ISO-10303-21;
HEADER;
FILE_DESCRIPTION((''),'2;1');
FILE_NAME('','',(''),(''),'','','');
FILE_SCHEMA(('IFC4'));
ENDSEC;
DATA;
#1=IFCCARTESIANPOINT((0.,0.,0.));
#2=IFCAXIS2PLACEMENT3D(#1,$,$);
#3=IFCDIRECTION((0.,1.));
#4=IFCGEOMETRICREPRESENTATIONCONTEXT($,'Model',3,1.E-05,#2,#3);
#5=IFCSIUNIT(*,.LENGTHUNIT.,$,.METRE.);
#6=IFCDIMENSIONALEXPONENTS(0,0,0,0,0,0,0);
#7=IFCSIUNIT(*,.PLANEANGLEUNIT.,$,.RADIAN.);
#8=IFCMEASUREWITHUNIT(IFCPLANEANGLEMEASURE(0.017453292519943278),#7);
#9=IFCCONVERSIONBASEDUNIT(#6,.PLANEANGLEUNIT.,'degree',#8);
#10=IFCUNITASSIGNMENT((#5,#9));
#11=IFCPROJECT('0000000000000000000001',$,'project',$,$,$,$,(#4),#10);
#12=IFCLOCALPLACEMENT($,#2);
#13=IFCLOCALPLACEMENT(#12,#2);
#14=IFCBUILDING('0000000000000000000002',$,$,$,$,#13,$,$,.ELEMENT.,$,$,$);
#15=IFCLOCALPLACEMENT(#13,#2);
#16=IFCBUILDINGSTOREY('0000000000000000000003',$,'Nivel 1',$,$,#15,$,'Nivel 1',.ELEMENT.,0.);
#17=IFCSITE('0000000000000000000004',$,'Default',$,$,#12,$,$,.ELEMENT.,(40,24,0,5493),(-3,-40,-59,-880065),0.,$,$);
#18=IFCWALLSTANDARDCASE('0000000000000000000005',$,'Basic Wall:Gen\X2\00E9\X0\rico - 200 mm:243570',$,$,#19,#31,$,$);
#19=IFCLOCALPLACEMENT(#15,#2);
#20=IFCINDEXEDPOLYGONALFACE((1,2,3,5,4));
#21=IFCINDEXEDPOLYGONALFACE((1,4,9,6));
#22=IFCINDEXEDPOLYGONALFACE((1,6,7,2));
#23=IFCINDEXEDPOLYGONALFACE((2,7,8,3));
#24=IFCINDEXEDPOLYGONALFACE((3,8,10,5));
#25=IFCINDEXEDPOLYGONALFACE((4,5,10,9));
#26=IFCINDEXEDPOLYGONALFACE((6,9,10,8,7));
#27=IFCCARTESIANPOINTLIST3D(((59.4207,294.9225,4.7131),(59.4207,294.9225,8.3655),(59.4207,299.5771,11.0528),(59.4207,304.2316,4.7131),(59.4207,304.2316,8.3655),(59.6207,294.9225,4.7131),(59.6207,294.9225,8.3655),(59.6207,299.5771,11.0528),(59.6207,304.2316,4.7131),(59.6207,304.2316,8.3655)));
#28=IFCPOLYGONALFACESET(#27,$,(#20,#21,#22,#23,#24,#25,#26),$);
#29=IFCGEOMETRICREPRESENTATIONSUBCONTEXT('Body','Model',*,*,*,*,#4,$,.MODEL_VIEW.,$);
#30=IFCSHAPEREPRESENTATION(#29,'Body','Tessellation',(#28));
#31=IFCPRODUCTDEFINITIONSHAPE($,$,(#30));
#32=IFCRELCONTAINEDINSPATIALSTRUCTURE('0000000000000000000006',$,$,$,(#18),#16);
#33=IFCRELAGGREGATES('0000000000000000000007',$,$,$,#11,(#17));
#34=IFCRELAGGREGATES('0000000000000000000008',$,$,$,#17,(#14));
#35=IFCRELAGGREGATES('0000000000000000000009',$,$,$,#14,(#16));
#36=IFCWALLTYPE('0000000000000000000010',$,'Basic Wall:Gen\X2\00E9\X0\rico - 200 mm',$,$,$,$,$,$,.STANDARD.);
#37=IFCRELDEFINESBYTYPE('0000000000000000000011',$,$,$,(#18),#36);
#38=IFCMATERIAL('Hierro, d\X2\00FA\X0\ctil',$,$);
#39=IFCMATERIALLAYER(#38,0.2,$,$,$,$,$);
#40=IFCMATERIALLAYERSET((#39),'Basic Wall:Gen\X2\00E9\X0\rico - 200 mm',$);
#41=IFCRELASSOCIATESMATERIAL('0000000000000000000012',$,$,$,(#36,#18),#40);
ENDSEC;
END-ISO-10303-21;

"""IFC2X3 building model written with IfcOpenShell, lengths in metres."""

from ifc_helpers import new_model, entity, si_unit, converted_unit, direction, frame, frame_2d, origin, place, context, subcontext, project, spatial, polyline, rectangle, extrude, clip, bounded_halfspace, material, layer, layer_set, layer_usage, type_object, element, save


model = new_model("IFC2X3")

# Units and contexts
model_context = context("Model", 3, precision=1e-05, world=origin(), true_north=direction((0.0, 1.0)))
body_context = subcontext(model_context, "Body", "Model", "MODEL_VIEW")
ifc_project = project(units=[si_unit("LENGTHUNIT", "METRE"), converted_unit("PLANEANGLEUNIT", "degree", entity("IfcPlaneAngleMeasure", 0.017453292519943278), si_unit("PLANEANGLEUNIT", "RADIAN"), dimensions=[0, 0, 0, 0, 0, 0, 0])], contexts=[model_context])

# Site, building, storey
site_placement = place(None, origin())
site = spatial("IfcSite", under=ifc_project, at=site_placement, Name="Default", CompositionType="ELEMENT", RefLatitude=(40, 24, 0, 5493), RefLongitude=(-3, -40, -59, -880065), RefElevation=0.0)
building_placement = place(site_placement, origin())
building = spatial("IfcBuilding", under=site, at=building_placement, CompositionType="ELEMENT")
storey_placement = place(building_placement, origin())
storey = spatial("IfcBuildingStorey", under=building, at=storey_placement, Name="Nivel 1", LongName="Nivel 1", CompositionType="ELEMENT", Elevation=0.0)

# Wall
ifc_material_1 = material(Name="Hierro, dúctil")
ifc_layer_1 = layer(ifc_material_1, 0.2)
ifc_layer_set_1 = layer_set([ifc_layer_1], Name="Basic Wall:Genérico - 200 mm")
wall_type = type_object("IfcWallType", Name="Basic Wall:Genérico - 200 mm", PredefinedType="STANDARD", material=ifc_layer_set_1)
ifc_layer_usage_1 = layer_usage(ifc_layer_set_1, "AXIS2", "NEGATIVE", 0.1)
wall_1_placement = place(storey_placement, frame((59.5207, 304.2316, 4.7131), z_axis=(0.0, 0.0, 1.0), x_axis=(0.0, -1.0, 0.0)))
element("IfcWallStandardCase", 1, at=wall_1_placement, inside=storey, type_object=wall_type, material=ifc_layer_usage_1, Name="Basic Wall:Genérico - 200 mm:243570", context=body_context, shape_type="Clipping", body=[
    clip(clip(extrude(rectangle(XDim=9.3091, YDim=0.2, at=frame_2d((4.6546, 0.0), x_axis=(-1.0, 0.0))), origin(), (0.0, 0.0, 1.0), 6.3397), bounded_halfspace(frame((0.0, -0.1, 3.6524), z_axis=(-0.5, 0.0, 0.866025), x_axis=(0.0, -1.0, 0.0)), False, frame((0.0, -0.1, 3.6524)), polyline([(0.0, 0.0), (4.6546, 0.0), (4.6546, 0.2), (0.0, 0.2), (0.0, 0.0)]))), bounded_halfspace(frame((4.6546, -0.1, 6.3397), z_axis=(0.5, 0.0, 0.866025), x_axis=(0.0, 1.0, 0.0)), False, frame((4.6546, -0.1, 6.3397)), polyline([(0.0, 0.0), (4.6546, 0.0), (4.6546, 0.2), (0.0, 0.2), (0.0, 0.0)]))),
])

save(model, "model.ifc")
